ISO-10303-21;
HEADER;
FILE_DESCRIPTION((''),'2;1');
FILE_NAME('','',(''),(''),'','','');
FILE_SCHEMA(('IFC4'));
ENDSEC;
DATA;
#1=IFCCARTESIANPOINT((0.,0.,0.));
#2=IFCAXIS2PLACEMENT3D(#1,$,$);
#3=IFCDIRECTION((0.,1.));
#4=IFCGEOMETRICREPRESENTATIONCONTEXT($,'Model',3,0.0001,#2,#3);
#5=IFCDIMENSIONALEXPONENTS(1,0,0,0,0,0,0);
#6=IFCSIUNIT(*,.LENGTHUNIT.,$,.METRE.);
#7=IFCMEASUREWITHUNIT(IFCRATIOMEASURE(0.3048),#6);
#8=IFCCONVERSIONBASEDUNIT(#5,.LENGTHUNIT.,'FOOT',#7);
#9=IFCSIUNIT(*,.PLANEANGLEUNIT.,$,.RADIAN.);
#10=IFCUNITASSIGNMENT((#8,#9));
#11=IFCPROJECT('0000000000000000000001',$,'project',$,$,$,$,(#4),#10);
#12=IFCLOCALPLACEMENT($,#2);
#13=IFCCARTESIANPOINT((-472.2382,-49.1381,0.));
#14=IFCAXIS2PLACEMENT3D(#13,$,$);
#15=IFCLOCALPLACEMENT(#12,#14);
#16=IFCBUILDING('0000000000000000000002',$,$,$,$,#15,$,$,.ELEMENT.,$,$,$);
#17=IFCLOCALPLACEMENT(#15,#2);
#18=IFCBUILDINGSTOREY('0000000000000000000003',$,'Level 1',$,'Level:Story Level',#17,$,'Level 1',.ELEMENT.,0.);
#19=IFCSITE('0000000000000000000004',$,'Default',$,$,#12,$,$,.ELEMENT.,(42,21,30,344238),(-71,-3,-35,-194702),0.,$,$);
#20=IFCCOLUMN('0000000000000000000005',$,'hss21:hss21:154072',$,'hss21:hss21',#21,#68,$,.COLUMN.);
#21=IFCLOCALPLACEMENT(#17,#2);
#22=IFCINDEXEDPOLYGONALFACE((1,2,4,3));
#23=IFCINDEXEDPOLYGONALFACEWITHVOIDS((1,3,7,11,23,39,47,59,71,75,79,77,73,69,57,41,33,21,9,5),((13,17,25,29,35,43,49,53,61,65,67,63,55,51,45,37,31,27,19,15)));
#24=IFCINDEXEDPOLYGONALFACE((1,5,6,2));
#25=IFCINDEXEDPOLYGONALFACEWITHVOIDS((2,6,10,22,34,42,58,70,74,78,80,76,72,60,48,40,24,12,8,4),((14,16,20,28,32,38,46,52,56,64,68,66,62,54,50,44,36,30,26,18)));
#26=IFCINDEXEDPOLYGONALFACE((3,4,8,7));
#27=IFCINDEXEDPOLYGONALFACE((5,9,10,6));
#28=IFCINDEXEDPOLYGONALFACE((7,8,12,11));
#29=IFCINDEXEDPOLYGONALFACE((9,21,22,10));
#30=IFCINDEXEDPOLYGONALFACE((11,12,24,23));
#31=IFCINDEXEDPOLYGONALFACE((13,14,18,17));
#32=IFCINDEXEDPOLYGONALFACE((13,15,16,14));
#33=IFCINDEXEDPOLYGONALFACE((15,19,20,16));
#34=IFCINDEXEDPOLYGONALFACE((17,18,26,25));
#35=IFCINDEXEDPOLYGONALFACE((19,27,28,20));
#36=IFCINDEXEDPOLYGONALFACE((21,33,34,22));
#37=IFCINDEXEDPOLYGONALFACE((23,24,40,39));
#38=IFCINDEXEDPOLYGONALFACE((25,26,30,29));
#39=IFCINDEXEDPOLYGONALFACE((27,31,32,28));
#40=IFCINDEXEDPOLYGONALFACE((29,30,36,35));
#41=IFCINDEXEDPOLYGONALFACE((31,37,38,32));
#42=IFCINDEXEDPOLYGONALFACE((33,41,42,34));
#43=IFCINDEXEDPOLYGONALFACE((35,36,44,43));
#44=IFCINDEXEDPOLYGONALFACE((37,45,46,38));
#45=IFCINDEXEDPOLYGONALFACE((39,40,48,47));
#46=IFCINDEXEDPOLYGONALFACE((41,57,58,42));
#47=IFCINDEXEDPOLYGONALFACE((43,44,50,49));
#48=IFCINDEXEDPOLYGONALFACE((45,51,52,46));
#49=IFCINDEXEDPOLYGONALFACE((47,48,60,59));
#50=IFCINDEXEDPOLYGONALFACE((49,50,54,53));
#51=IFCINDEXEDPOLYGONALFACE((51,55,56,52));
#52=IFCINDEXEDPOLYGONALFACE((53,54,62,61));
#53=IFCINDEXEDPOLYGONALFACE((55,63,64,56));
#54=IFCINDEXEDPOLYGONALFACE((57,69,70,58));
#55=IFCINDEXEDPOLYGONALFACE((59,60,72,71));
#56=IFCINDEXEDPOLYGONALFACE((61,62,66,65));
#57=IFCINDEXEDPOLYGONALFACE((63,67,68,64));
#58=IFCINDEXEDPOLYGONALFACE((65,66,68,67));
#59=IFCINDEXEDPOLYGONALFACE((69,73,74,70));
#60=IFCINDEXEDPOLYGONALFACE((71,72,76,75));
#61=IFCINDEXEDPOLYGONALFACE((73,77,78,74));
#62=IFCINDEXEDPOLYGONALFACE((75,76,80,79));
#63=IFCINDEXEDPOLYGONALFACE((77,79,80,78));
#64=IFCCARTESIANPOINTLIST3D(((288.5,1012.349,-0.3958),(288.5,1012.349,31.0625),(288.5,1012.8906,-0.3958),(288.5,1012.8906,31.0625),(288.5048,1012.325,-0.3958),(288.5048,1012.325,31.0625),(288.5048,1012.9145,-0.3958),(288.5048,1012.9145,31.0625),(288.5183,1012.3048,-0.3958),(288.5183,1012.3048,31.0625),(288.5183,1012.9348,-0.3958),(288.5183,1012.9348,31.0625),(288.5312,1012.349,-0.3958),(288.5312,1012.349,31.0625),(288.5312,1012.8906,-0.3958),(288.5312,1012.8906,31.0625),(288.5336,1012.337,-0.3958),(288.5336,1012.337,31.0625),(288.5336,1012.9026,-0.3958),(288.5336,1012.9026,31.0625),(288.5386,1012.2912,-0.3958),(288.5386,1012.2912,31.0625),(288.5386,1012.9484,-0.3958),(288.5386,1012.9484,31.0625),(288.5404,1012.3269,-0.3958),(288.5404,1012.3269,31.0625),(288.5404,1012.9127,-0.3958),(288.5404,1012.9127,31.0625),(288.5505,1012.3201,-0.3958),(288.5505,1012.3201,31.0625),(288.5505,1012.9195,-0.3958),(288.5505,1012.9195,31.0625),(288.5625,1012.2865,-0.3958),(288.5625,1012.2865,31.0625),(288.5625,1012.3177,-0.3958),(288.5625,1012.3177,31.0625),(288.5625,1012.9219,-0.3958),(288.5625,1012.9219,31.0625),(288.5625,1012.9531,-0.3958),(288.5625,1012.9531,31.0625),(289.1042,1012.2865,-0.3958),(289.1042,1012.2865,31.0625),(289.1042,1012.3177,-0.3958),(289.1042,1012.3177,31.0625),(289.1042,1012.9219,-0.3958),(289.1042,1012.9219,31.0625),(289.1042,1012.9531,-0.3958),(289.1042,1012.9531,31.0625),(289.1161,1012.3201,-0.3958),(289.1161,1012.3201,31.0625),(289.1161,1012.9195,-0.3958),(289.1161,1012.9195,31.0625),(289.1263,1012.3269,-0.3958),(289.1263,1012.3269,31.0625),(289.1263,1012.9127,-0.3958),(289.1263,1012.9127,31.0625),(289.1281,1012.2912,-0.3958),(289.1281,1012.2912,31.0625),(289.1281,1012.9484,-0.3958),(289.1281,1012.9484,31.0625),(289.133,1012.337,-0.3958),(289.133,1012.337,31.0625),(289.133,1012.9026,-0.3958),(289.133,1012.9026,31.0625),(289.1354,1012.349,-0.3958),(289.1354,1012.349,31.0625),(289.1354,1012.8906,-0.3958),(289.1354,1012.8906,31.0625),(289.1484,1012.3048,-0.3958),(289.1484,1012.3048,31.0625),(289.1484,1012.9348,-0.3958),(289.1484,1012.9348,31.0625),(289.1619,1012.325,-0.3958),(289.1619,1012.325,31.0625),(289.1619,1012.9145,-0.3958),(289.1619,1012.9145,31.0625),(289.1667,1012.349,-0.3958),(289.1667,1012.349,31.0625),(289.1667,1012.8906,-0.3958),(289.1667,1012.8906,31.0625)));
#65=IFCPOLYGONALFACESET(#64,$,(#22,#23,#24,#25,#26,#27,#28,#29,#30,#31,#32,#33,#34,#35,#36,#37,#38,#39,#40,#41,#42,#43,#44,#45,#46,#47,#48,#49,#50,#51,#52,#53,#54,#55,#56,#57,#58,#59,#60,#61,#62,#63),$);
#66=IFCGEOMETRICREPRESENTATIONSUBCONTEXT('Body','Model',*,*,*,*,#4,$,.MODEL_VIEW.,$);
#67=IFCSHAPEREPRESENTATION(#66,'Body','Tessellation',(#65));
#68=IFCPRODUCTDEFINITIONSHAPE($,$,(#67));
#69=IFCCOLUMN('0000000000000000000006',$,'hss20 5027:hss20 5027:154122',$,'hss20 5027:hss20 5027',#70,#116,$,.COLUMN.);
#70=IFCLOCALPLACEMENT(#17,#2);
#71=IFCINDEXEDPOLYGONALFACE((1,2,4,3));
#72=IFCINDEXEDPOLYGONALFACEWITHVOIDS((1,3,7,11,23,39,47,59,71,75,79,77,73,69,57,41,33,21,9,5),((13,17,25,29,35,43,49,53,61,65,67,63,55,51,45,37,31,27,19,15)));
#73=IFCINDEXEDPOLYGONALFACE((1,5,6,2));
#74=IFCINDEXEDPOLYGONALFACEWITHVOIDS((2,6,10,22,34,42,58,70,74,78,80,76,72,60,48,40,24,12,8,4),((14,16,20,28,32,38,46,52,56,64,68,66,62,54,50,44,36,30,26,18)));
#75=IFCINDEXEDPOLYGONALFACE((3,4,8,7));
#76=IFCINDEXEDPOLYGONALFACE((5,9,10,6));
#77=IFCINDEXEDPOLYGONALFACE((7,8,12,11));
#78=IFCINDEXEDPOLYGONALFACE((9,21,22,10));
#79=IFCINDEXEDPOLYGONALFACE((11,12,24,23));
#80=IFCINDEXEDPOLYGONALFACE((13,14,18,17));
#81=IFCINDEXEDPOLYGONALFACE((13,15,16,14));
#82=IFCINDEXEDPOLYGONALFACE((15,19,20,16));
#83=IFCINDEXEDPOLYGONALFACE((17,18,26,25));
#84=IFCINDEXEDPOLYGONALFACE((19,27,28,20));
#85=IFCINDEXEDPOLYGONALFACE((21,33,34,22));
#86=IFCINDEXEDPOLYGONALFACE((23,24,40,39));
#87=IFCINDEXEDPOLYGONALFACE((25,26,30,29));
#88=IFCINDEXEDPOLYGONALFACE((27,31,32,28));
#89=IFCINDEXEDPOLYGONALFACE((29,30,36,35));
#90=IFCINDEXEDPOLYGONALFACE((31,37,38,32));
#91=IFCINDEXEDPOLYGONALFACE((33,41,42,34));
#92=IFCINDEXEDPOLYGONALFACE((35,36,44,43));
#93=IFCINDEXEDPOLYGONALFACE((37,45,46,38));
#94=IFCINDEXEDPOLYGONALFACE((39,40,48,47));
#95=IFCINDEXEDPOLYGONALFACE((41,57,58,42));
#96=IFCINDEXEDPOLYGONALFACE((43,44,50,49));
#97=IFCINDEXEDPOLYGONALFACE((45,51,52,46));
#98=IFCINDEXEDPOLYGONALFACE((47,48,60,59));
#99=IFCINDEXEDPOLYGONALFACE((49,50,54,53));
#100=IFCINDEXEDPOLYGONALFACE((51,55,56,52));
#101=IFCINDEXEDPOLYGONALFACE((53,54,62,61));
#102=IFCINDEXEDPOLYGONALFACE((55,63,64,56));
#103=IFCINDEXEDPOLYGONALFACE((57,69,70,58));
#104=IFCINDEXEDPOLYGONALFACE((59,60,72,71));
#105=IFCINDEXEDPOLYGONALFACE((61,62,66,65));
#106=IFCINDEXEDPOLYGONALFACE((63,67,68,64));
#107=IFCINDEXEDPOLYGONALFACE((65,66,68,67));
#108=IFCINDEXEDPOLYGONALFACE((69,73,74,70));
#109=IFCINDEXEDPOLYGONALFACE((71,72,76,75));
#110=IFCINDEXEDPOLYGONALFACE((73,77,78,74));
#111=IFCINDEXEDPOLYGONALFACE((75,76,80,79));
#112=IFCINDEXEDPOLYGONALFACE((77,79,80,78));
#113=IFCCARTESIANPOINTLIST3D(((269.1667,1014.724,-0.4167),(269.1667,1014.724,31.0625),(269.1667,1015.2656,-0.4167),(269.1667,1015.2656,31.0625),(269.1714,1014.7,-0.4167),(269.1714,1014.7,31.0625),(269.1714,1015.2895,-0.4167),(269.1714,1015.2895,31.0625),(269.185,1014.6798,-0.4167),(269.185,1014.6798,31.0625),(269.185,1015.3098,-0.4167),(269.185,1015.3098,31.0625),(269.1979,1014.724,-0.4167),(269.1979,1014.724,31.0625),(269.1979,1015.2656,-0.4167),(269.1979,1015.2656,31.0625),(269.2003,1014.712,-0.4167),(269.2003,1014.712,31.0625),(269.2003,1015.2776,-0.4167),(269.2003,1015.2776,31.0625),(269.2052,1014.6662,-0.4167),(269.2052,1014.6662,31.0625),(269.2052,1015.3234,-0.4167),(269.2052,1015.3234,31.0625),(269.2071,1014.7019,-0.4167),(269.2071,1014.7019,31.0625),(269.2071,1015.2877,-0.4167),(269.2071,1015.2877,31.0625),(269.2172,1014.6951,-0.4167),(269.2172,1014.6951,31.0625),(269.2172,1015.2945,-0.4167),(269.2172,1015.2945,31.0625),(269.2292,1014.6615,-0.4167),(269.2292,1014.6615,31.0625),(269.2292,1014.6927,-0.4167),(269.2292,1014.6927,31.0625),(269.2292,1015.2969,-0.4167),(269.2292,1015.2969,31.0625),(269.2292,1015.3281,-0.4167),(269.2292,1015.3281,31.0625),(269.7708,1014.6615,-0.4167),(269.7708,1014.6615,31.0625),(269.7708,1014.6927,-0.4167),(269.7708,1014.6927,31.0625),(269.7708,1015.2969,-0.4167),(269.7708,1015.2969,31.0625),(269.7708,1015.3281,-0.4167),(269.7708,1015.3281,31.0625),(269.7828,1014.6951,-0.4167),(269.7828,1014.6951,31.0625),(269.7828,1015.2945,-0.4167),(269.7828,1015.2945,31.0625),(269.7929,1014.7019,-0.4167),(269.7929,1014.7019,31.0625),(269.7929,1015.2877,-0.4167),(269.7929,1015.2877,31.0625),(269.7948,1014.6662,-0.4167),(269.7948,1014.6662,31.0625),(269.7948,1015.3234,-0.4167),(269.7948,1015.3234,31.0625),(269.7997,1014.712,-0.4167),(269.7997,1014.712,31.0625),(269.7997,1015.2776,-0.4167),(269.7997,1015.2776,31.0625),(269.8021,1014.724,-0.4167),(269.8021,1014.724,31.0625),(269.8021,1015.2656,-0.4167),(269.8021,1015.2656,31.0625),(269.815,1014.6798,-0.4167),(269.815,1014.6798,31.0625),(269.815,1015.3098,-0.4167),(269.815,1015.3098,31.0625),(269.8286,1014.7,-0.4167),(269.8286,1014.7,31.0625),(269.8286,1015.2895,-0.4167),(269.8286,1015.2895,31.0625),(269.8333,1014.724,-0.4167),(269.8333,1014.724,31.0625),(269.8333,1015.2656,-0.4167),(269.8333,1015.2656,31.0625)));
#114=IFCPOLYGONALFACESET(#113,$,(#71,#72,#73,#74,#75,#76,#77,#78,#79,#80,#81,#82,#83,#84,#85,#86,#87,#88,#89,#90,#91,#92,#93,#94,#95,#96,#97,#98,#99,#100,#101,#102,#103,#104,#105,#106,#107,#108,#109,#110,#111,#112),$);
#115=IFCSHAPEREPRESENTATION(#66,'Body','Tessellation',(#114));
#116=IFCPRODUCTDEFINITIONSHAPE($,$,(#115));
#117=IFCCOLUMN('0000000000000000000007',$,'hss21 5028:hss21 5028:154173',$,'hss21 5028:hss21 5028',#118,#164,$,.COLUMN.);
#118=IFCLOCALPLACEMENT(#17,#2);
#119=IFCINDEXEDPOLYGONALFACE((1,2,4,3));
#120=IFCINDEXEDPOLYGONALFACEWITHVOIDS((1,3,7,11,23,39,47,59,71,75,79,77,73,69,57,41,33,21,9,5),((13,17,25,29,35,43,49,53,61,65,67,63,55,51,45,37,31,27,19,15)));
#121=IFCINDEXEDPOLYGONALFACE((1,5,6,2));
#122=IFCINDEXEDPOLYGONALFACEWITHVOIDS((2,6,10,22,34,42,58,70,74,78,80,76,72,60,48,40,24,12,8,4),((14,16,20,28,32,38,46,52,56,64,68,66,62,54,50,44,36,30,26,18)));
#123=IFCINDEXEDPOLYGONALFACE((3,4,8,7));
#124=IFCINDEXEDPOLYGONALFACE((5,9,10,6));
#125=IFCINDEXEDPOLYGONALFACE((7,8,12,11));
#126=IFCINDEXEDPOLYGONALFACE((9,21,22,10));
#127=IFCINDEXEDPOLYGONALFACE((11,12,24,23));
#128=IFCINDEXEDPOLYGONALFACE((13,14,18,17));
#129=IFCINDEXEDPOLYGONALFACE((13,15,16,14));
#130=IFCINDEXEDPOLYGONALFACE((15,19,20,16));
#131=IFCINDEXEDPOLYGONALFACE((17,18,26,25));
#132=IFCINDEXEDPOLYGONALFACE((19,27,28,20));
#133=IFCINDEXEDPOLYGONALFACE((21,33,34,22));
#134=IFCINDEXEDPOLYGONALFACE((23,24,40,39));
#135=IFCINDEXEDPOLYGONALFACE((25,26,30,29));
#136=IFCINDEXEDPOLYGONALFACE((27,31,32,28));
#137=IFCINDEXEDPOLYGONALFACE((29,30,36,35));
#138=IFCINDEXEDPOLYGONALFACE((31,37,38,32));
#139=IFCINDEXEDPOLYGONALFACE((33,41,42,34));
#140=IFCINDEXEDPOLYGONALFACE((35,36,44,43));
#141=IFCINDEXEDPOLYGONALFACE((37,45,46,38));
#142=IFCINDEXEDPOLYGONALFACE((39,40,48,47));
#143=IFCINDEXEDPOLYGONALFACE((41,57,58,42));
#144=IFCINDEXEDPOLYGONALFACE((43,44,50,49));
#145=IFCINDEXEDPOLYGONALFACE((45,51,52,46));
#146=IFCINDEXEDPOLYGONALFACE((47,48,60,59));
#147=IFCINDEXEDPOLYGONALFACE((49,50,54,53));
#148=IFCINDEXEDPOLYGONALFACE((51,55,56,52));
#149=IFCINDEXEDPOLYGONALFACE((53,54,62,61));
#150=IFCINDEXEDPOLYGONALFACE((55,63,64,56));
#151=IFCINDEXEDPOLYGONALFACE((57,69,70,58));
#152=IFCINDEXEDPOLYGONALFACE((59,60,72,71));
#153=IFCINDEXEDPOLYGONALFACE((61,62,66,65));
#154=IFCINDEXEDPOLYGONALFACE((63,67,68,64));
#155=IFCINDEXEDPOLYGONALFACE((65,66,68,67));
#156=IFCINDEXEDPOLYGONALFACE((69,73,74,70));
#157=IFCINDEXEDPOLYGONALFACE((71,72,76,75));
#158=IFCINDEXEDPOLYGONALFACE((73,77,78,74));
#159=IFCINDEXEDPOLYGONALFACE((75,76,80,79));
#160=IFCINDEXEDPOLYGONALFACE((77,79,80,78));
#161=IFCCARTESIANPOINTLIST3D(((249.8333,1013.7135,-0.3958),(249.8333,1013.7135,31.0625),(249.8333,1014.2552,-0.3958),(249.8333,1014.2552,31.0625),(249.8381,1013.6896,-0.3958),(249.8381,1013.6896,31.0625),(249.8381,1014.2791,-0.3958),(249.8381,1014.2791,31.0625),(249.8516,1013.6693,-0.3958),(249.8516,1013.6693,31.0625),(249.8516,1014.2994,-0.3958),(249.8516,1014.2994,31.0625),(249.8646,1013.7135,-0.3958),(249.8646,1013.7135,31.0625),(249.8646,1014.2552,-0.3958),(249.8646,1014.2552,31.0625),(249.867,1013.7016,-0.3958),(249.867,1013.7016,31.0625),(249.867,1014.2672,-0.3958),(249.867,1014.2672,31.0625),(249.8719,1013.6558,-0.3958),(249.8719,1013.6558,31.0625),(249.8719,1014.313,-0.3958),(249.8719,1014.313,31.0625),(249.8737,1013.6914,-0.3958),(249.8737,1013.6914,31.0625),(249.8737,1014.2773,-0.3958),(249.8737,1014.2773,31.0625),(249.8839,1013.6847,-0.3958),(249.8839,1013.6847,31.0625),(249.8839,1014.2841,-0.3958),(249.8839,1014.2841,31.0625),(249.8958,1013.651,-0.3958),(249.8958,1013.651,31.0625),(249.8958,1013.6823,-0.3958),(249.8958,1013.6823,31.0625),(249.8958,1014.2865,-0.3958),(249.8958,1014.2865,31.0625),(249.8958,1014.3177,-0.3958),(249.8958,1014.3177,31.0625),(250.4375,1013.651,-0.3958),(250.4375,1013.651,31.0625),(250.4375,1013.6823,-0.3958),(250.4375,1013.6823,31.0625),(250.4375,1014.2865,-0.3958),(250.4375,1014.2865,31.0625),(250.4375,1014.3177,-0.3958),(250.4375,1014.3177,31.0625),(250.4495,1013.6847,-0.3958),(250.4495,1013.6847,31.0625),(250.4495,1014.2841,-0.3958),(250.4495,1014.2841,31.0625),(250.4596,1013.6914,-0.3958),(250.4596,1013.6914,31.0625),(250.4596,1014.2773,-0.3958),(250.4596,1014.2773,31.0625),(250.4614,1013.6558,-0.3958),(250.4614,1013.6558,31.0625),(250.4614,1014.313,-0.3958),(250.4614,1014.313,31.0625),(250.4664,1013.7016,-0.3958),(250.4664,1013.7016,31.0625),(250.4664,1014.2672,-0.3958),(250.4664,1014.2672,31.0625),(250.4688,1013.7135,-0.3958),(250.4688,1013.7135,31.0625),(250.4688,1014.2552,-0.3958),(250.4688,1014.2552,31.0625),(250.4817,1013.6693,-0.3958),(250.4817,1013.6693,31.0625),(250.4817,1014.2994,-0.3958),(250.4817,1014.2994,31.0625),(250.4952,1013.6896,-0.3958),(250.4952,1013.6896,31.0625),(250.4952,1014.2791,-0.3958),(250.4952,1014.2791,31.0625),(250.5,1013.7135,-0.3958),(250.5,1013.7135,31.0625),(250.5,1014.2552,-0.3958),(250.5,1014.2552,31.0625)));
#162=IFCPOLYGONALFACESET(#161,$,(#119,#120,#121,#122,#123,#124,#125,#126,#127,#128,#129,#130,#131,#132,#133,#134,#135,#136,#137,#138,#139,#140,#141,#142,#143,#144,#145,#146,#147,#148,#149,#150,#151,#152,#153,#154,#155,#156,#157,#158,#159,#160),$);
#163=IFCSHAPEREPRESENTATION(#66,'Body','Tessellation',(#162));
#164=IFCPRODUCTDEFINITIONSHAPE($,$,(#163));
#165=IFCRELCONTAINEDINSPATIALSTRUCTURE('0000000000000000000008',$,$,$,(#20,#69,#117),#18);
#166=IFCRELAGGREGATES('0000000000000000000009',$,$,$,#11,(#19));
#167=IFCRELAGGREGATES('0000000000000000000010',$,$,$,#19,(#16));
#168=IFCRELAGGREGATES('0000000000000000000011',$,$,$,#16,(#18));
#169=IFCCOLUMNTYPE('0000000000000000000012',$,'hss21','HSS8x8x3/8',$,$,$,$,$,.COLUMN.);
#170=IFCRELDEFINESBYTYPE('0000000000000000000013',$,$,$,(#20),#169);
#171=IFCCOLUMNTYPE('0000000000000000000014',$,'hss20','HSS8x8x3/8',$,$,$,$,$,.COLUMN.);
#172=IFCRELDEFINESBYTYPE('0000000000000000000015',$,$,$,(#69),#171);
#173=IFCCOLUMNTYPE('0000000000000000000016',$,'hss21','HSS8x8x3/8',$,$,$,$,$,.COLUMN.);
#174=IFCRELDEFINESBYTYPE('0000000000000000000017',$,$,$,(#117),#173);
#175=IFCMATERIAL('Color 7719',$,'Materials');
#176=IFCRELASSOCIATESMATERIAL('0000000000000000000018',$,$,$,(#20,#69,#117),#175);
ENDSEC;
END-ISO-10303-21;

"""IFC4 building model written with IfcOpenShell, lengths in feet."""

from ifc_helpers import new_model, entity, si_unit, converted_unit, direction, frame, origin, place, context, subcontext, project, spatial, polyline, outline, extrude, boolean, source, transform, mapped, material, type_object, type_shapes, element, save


model = new_model("IFC4")

# Units and contexts
model_context = context("Model", 3, precision=0.0001, world=origin(), true_north=direction((0.0, 1.0)))
body_context = subcontext(model_context, "Body", "Model", "MODEL_VIEW")
ifc_project = project(units=[converted_unit("LENGTHUNIT", "FOOT", entity("IfcRatioMeasure", 0.3048), si_unit("LENGTHUNIT", "METRE"), dimensions=[1, 0, 0, 0, 0, 0, 0]), si_unit("PLANEANGLEUNIT", "RADIAN")], contexts=[model_context])

# Site, building, storey
site_placement = place(None, origin())
site = spatial("IfcSite", under=ifc_project, at=site_placement, Name="Default", CompositionType="ELEMENT", RefLatitude=(42, 21, 30, 344238), RefLongitude=(-71, -3, -35, -194702), RefElevation=0.0)
building_placement = place(site_placement, frame((-472.2382, -49.1381, 0.0)))
building = spatial("IfcBuilding", under=site, at=building_placement, CompositionType="ELEMENT")
storey_placement = place(building_placement, origin())
storey = spatial("IfcBuildingStorey", under=building, at=storey_placement, Name="Level 1", ObjectType="Level:Story Level", LongName="Level 1", CompositionType="ELEMENT", Elevation=0.0)

# Columns
ifc_material_1 = material(Name="Color 7719", Category="Materials")
column_type_1 = type_object("IfcColumnType", Name="hss21", Description="HSS8x8x3/8", PredefinedType="COLUMN")
shared_shape_1 = source(origin(), body_context, "Body", "CSG", [
    boolean("DIFFERENCE", extrude(outline(polyline([(-0.2708, -0.3333), (0.2708, -0.3333), (0.2948, -0.3286), (0.315, -0.315), (0.3286, -0.2948), (0.3333, -0.2708), (0.3333, 0.2708), (0.3286, 0.2948), (0.315, 0.315), (0.2948, 0.3286), (0.2708, 0.3333), (-0.2708, 0.3333), (-0.2948, 0.3286), (-0.315, 0.315), (-0.3286, 0.2948), (-0.3333, 0.2708), (-0.3333, -0.2708), (-0.3286, -0.2948), (-0.315, -0.315), (-0.2948, -0.3286), (-0.2708, -0.3333)])), frame((288.8333, 1012.6198, -0.3958), z_axis=(0.0, 0.0, 1.0), x_axis=(0.0, -1.0, 0.0)), (0.0, 0.0, 1.0), 31.4583), extrude(outline(polyline([(-0.2708, -0.3021), (0.2708, -0.3021), (0.2828, -0.2997), (0.2929, -0.2929), (0.2997, -0.2828), (0.3021, -0.2708), (0.3021, 0.2708), (0.2997, 0.2828), (0.2929, 0.2929), (0.2828, 0.2997), (0.2708, 0.3021), (-0.2708, 0.3021), (-0.2828, 0.2997), (-0.2929, 0.2929), (-0.2997, 0.2828), (-0.3021, 0.2708), (-0.3021, -0.2708), (-0.2997, -0.2828), (-0.2929, -0.2929), (-0.2828, -0.2997), (-0.2708, -0.3021)])), frame((288.8333, 1012.6198, 31.0625), z_axis=(0.0, 0.0, -1.0), x_axis=(0.0, -1.0, 0.0)), (0.0, 0.0, 1.0), 31.4583)),
])
type_shapes(column_type_1, [shared_shape_1])
column_1_placement = place(building_placement, origin())
element("IfcColumn", 1, at=column_1_placement, inside=storey, type_object=column_type_1, material=ifc_material_1, Name="hss21:hss21:154072", ObjectType="hss21:hss21", PredefinedType="COLUMN", context=body_context, shape_type="MappedRepresentation", body=[
    mapped(shared_shape_1, transform((0.0, 0.0, 0.0), scale=1.0)),
])
column_type_2 = type_object("IfcColumnType", Name="hss20", Description="HSS8x8x3/8", PredefinedType="COLUMN")
shared_shape_2 = source(origin(), body_context, "Body", "CSG", [
    boolean("DIFFERENCE", extrude(outline(polyline([(-0.2708, -0.3333), (0.2708, -0.3333), (0.2948, -0.3286), (0.315, -0.315), (0.3286, -0.2948), (0.3333, -0.2708), (0.3333, 0.2708), (0.3286, 0.2948), (0.315, 0.315), (0.2948, 0.3286), (0.2708, 0.3333), (-0.2708, 0.3333), (-0.2948, 0.3286), (-0.315, 0.315), (-0.3286, 0.2948), (-0.3333, 0.2708), (-0.3333, -0.2708), (-0.3286, -0.2948), (-0.315, -0.315), (-0.2948, -0.3286), (-0.2708, -0.3333)])), frame((269.5, 1014.9948, -0.4167), z_axis=(0.0, 0.0, 1.0), x_axis=(0.0, -1.0, 0.0)), (0.0, 0.0, 1.0), 31.4792), extrude(outline(polyline([(-0.2708, -0.3021), (0.2708, -0.3021), (0.2828, -0.2997), (0.2929, -0.2929), (0.2997, -0.2828), (0.3021, -0.2708), (0.3021, 0.2708), (0.2997, 0.2828), (0.2929, 0.2929), (0.2828, 0.2997), (0.2708, 0.3021), (-0.2708, 0.3021), (-0.2828, 0.2997), (-0.2929, 0.2929), (-0.2997, 0.2828), (-0.3021, 0.2708), (-0.3021, -0.2708), (-0.2997, -0.2828), (-0.2929, -0.2929), (-0.2828, -0.2997), (-0.2708, -0.3021)])), frame((269.5, 1014.9948, 31.0625), z_axis=(0.0, 0.0, -1.0), x_axis=(0.0, -1.0, 0.0)), (0.0, 0.0, 1.0), 31.4792)),
])
type_shapes(column_type_2, [shared_shape_2])
column_2_placement = place(building_placement, origin())
element("IfcColumn", 2, at=column_2_placement, inside=storey, type_object=column_type_2, material=ifc_material_1, Name="hss20 5027:hss20 5027:154122", ObjectType="hss20 5027:hss20 5027", PredefinedType="COLUMN", context=body_context, shape_type="MappedRepresentation", body=[
    mapped(shared_shape_2, transform((0.0, 0.0, 0.0), scale=1.0)),
])
column_type_3 = type_object("IfcColumnType", Name="hss21", Description="HSS8x8x3/8", PredefinedType="COLUMN")
shared_shape_3 = source(origin(), body_context, "Body", "CSG", [
    boolean("DIFFERENCE", extrude(outline(polyline([(-0.2708, -0.3333), (0.2708, -0.3333), (0.2948, -0.3286), (0.315, -0.315), (0.3286, -0.2948), (0.3333, -0.2708), (0.3333, 0.2708), (0.3286, 0.2948), (0.315, 0.315), (0.2948, 0.3286), (0.2708, 0.3333), (-0.2708, 0.3333), (-0.2948, 0.3286), (-0.315, 0.315), (-0.3286, 0.2948), (-0.3333, 0.2708), (-0.3333, -0.2708), (-0.3286, -0.2948), (-0.315, -0.315), (-0.2948, -0.3286), (-0.2708, -0.3333)])), frame((250.1667, 1013.9844, -0.3958), z_axis=(0.0, 0.0, 1.0), x_axis=(0.0, -1.0, 0.0)), (0.0, 0.0, 1.0), 31.4583), extrude(outline(polyline([(-0.2708, -0.3021), (0.2708, -0.3021), (0.2828, -0.2997), (0.2929, -0.2929), (0.2997, -0.2828), (0.3021, -0.2708), (0.3021, 0.2708), (0.2997, 0.2828), (0.2929, 0.2929), (0.2828, 0.2997), (0.2708, 0.3021), (-0.2708, 0.3021), (-0.2828, 0.2997), (-0.2929, 0.2929), (-0.2997, 0.2828), (-0.3021, 0.2708), (-0.3021, -0.2708), (-0.2997, -0.2828), (-0.2929, -0.2929), (-0.2828, -0.2997), (-0.2708, -0.3021)])), frame((250.1667, 1013.9844, 31.0625), z_axis=(0.0, 0.0, -1.0), x_axis=(0.0, -1.0, 0.0)), (0.0, 0.0, 1.0), 31.4583)),
])
type_shapes(column_type_3, [shared_shape_3])
column_3_placement = place(building_placement, origin())
element("IfcColumn", 3, at=column_3_placement, inside=storey, type_object=column_type_3, material=ifc_material_1, Name="hss21 5028:hss21 5028:154173", ObjectType="hss21 5028:hss21 5028", PredefinedType="COLUMN", context=body_context, shape_type="MappedRepresentation", body=[
    mapped(shared_shape_3, transform((0.0, 0.0, 0.0), scale=1.0)),
])

save(model, "model.ifc")
